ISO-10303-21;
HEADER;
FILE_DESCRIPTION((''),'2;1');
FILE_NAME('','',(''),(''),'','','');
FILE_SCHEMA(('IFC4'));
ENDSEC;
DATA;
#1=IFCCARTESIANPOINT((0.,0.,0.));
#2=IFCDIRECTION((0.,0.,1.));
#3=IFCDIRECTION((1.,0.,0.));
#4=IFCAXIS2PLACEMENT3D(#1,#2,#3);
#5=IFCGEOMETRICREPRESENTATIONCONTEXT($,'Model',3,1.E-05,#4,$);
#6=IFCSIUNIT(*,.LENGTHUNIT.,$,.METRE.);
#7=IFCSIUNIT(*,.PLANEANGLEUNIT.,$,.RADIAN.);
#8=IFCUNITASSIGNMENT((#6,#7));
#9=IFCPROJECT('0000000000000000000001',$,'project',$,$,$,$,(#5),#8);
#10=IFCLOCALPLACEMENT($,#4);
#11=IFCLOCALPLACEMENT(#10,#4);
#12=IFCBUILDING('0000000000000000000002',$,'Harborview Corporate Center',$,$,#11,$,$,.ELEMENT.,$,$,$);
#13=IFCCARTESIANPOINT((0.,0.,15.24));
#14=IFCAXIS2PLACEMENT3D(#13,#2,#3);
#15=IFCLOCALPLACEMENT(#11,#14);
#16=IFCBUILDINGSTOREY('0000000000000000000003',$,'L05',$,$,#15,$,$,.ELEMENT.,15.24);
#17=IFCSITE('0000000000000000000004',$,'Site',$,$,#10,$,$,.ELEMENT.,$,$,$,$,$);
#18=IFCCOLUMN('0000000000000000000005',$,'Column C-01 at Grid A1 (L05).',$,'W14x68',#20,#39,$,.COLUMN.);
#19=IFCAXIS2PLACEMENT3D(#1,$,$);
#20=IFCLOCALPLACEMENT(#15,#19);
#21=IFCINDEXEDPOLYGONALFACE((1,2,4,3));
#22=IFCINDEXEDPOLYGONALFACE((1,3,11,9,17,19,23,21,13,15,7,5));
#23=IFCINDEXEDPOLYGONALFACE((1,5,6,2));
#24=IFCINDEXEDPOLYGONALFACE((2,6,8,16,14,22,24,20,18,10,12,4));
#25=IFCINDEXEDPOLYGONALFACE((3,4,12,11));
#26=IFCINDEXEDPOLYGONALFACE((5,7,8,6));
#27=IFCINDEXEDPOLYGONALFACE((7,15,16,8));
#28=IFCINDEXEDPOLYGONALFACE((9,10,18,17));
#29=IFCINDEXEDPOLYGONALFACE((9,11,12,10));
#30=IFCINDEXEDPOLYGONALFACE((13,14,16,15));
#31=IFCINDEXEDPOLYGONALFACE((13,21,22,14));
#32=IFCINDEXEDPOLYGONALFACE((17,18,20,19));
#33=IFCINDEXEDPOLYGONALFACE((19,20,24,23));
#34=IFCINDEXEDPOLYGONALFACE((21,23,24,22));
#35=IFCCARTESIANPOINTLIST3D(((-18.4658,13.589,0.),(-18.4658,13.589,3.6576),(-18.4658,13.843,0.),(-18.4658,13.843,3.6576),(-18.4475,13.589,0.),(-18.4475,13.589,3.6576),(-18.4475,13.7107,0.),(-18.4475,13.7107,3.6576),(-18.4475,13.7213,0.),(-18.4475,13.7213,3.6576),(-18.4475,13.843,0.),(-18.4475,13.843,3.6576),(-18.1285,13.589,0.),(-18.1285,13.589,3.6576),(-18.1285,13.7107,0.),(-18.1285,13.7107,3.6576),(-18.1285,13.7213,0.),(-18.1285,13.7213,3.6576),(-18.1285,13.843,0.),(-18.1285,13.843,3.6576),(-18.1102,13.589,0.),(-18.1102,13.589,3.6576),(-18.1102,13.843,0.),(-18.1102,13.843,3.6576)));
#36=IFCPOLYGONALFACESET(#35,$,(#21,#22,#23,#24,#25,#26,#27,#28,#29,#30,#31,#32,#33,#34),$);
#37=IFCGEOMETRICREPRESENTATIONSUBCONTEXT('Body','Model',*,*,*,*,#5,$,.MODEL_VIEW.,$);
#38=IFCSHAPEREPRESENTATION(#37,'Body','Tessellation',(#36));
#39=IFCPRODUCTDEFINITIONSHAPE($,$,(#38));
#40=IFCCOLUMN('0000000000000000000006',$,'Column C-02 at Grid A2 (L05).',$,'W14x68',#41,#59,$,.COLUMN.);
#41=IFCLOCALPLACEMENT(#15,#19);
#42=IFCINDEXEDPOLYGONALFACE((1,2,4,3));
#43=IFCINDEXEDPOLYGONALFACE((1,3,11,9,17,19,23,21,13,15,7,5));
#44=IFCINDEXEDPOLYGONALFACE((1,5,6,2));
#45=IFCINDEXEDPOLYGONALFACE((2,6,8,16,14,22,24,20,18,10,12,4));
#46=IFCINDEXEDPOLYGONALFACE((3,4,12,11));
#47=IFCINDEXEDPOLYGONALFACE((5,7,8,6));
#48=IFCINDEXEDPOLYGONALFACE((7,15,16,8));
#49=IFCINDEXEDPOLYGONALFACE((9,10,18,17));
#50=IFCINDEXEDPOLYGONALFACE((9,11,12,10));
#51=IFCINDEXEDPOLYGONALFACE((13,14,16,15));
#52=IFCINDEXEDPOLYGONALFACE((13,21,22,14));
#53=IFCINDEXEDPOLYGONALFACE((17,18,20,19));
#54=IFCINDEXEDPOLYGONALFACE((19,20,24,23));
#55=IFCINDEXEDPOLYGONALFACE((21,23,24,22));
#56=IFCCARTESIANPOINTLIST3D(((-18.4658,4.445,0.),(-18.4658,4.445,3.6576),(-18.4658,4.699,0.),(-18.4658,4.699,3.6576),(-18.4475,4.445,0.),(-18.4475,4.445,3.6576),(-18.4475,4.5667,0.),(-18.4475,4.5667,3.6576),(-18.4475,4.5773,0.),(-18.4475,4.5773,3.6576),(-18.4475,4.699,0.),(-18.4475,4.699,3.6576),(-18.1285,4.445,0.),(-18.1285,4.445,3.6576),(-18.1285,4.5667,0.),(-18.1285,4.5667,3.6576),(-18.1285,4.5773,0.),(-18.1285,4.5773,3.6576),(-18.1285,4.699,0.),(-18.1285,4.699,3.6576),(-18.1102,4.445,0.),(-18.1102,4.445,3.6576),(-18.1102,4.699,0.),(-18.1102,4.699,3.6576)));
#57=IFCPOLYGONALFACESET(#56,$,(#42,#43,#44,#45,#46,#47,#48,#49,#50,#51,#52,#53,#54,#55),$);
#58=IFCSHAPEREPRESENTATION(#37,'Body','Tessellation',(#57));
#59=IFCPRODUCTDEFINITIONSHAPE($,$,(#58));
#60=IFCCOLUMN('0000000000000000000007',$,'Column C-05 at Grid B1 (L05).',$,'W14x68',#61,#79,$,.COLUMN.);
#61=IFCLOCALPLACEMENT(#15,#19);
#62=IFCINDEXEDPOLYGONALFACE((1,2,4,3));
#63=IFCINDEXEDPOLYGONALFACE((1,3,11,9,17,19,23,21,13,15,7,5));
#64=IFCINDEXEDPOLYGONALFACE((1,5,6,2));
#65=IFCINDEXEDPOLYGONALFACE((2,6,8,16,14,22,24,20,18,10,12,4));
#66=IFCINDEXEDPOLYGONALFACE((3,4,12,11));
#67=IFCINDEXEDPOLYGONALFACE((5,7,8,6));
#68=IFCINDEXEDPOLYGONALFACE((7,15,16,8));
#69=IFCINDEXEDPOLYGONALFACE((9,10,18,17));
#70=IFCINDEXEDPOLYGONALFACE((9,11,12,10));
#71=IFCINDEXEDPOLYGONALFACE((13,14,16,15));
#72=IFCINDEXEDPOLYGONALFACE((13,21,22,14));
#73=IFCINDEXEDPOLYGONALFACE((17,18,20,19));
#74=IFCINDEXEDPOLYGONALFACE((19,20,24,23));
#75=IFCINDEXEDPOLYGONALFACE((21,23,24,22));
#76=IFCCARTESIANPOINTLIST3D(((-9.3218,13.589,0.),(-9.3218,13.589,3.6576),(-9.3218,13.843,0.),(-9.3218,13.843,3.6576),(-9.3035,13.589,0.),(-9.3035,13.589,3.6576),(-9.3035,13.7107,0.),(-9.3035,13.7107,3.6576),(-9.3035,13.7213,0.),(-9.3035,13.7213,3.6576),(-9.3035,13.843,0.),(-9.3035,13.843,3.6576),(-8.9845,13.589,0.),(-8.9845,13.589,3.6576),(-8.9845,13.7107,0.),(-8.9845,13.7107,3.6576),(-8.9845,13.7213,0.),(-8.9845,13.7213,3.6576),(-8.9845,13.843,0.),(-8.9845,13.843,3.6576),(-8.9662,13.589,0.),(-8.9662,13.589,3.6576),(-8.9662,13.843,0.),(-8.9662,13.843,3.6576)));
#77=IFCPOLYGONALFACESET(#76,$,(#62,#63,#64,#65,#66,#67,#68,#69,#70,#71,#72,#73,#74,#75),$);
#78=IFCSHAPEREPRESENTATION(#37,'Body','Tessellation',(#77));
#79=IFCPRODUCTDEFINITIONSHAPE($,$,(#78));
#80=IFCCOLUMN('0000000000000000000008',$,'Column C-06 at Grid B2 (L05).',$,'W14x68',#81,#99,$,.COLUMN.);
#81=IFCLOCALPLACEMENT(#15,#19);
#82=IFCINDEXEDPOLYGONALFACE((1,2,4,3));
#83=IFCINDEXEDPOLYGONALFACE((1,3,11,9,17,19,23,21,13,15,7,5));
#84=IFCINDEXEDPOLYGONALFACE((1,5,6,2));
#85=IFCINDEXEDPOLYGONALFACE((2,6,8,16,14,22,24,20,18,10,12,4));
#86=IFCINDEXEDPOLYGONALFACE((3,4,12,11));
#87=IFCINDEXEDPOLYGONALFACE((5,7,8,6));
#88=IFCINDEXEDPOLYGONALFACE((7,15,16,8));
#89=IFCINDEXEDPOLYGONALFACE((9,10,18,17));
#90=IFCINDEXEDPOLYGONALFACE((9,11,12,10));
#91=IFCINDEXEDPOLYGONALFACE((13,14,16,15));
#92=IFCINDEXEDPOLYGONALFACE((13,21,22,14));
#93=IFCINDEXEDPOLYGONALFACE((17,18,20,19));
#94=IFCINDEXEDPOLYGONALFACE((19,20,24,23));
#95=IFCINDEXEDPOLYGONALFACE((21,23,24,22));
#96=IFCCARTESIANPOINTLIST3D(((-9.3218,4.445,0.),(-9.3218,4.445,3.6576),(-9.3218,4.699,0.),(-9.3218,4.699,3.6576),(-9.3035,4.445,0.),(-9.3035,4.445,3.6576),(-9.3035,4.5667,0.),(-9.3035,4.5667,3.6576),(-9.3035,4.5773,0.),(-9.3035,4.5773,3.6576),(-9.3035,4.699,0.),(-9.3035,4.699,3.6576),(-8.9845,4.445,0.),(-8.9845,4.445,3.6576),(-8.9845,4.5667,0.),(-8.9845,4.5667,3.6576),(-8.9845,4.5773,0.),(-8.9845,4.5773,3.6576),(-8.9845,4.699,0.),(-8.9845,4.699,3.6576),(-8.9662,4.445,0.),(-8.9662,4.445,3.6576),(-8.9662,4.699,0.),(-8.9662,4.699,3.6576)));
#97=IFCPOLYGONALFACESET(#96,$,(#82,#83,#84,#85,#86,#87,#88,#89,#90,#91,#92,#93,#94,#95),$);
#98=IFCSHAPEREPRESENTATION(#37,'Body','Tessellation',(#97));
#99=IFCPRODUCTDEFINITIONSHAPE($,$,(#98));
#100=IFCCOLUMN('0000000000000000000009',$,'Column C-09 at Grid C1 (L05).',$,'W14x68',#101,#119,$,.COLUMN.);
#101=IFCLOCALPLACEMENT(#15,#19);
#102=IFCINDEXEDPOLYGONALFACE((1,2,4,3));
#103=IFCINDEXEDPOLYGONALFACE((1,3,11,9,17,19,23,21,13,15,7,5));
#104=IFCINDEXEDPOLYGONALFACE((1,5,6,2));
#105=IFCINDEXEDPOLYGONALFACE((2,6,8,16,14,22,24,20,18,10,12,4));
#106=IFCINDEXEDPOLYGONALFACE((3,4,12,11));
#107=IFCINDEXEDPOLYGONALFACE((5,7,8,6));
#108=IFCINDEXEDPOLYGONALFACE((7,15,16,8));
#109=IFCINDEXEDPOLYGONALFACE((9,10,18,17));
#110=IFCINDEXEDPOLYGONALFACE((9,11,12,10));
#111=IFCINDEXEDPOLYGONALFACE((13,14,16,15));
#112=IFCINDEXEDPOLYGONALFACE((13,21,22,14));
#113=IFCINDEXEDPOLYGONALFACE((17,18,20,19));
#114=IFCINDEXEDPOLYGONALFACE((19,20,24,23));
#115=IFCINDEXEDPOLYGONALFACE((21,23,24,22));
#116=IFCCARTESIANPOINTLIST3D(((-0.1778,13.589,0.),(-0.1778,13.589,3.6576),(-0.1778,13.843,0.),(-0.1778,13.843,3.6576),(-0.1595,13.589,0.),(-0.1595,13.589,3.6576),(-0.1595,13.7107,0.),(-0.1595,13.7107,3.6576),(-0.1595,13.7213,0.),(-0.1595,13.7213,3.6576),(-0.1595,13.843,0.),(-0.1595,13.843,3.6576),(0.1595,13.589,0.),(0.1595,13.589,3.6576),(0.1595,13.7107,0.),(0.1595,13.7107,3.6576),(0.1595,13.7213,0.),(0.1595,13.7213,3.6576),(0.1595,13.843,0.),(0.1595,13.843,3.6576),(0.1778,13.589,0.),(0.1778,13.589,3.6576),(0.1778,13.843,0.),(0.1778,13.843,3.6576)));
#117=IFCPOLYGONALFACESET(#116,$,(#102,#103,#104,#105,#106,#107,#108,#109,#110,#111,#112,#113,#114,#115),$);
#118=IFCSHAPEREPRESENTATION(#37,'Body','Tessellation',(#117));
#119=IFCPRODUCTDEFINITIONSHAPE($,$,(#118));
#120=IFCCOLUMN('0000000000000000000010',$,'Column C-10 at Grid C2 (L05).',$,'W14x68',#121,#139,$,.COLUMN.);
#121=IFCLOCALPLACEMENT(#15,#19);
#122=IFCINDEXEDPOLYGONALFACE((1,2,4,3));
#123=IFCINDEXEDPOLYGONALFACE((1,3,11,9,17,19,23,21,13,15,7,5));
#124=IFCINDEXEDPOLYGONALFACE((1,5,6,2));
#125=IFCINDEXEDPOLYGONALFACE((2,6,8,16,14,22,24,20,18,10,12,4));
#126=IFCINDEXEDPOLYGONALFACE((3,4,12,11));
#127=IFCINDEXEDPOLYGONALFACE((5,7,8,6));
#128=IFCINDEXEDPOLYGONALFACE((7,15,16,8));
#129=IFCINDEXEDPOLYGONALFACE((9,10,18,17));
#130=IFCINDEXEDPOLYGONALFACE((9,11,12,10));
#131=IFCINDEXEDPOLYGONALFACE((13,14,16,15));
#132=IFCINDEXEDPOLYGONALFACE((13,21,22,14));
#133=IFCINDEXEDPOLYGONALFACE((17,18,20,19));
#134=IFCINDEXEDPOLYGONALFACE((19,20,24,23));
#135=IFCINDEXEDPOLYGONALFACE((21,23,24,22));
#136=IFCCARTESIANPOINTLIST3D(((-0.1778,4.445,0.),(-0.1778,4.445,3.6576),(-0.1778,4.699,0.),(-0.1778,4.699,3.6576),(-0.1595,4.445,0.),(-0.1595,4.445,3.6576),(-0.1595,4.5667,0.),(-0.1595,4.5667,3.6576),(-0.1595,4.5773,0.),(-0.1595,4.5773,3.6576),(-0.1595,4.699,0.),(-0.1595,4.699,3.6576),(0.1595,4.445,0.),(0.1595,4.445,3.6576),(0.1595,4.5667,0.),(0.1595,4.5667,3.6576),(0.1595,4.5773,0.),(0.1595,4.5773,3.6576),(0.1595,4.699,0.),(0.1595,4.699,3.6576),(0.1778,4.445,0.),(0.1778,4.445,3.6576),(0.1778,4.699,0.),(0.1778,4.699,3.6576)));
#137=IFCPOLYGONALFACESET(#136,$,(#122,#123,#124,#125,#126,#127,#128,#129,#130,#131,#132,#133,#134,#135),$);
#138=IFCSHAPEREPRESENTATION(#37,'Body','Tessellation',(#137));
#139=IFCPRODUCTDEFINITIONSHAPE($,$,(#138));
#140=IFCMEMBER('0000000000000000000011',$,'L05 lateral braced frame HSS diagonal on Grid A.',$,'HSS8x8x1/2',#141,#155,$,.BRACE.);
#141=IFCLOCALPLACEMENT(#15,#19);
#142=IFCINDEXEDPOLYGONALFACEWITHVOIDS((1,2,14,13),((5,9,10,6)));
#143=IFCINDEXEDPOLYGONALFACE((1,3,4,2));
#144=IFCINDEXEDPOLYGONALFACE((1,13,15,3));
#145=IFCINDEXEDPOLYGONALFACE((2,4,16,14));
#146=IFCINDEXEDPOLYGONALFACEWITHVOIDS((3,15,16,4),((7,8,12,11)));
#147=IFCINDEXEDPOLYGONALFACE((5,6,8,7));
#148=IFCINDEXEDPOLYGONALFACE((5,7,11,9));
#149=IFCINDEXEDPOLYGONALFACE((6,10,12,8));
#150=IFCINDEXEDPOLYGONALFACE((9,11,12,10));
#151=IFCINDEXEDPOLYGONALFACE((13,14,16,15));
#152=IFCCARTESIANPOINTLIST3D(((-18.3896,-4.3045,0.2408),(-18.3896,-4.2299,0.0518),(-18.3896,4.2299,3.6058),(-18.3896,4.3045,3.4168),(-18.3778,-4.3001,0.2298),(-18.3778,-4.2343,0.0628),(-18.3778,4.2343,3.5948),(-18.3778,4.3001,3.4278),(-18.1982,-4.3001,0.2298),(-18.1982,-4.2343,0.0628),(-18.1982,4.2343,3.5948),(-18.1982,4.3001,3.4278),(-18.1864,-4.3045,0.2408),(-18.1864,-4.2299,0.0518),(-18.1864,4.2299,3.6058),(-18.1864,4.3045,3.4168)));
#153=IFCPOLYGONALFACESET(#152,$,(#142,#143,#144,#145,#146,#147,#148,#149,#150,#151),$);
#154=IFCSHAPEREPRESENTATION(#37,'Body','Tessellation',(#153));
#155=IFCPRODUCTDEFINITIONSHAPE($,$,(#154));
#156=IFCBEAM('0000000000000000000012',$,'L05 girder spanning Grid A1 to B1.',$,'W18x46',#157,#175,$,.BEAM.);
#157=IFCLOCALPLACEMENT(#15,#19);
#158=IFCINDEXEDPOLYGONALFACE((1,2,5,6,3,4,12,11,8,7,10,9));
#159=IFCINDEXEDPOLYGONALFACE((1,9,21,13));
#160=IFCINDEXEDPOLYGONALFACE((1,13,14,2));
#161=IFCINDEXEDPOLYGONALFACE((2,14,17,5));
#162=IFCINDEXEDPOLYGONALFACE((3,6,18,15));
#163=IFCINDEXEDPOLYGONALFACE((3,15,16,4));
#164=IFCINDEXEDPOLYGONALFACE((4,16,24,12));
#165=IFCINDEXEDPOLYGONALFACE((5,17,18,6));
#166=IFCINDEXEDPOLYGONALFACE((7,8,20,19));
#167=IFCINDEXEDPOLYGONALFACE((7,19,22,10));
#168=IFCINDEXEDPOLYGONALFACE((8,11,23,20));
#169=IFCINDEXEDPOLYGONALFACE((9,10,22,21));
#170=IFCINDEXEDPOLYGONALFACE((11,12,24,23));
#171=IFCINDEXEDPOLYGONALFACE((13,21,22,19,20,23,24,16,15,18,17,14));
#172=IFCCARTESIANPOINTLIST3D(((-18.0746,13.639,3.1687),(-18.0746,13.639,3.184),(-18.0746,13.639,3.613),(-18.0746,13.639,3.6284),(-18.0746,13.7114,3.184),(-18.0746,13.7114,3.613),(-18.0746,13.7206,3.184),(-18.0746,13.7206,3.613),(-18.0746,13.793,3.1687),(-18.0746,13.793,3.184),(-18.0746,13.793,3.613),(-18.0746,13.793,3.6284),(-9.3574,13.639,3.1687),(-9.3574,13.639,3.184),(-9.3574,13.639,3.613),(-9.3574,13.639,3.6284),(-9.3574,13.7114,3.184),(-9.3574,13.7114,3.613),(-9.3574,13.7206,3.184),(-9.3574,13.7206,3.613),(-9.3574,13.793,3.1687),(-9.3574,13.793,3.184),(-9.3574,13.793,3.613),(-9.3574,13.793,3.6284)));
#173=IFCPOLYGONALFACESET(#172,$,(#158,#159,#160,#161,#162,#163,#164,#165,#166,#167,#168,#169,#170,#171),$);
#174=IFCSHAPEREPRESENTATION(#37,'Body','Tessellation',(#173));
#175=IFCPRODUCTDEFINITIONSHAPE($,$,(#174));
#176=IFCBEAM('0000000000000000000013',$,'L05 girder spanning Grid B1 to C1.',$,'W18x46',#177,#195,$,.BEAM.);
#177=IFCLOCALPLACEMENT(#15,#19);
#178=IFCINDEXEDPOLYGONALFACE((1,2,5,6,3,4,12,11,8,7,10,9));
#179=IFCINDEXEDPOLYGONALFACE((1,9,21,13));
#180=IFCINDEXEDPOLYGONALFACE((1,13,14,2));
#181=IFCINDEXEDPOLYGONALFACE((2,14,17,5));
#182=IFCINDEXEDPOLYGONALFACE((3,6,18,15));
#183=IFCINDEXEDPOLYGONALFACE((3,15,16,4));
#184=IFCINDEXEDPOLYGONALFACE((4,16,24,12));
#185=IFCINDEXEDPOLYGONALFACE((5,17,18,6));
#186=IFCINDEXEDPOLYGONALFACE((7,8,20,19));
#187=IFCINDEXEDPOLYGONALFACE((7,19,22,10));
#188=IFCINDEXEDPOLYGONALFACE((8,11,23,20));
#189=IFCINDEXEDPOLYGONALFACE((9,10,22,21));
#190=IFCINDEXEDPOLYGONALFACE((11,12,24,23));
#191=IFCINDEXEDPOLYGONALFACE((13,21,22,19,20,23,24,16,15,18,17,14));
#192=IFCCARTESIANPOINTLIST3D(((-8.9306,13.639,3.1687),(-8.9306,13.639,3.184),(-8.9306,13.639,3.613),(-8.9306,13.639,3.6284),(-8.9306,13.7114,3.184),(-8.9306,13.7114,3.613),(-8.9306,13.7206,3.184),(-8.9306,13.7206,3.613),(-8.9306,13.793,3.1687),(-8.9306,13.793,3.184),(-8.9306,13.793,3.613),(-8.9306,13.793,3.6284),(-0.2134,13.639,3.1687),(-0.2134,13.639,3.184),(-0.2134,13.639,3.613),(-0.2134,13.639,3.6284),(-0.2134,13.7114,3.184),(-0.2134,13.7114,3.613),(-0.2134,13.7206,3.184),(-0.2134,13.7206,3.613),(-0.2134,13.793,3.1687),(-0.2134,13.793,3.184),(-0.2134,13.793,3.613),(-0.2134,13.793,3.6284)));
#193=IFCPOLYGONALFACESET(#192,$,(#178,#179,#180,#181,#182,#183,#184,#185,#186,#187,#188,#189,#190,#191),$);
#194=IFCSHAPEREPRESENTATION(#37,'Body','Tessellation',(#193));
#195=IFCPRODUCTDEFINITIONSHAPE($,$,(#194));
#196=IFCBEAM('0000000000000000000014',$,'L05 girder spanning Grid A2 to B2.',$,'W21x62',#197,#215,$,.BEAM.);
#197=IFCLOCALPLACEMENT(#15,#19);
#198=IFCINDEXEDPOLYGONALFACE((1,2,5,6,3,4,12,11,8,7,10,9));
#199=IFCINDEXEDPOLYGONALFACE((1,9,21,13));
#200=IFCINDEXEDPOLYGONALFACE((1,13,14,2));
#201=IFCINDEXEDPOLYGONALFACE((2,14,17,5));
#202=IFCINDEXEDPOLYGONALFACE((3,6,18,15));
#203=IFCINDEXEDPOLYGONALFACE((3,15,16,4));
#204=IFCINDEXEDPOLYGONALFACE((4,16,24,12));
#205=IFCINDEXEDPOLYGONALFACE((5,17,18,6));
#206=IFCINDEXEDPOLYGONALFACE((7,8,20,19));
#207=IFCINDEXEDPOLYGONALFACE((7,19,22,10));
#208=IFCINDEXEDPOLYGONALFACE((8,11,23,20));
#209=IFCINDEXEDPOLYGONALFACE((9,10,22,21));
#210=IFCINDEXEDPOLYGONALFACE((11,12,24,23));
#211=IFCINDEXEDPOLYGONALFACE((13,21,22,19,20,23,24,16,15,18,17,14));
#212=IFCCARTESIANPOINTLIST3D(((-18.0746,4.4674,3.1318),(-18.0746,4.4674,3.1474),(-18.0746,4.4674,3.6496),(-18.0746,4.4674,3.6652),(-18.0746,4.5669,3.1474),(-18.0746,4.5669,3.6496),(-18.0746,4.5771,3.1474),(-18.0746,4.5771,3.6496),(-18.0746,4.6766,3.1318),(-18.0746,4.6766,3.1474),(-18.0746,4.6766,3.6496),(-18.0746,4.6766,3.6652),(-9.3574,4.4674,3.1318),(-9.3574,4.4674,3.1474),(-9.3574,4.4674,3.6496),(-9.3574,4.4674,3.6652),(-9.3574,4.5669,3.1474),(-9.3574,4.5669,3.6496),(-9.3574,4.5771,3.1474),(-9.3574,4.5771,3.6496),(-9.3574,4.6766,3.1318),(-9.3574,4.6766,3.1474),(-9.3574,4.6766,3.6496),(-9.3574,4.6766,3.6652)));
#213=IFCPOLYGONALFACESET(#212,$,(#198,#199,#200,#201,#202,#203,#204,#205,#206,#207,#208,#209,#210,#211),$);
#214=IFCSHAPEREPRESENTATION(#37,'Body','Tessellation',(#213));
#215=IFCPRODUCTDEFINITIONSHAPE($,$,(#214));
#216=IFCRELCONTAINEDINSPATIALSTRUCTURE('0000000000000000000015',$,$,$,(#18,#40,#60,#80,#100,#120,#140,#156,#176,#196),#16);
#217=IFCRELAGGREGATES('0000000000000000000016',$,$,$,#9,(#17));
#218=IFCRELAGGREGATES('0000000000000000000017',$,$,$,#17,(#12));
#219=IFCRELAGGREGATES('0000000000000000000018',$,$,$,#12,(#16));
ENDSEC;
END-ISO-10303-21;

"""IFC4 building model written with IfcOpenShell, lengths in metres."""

from ifc_helpers import new_model, si_unit, frame, origin_with_axes, place, context, subcontext, project, spatial, hollow_rectangle, i_section, extrude, element, save


model = new_model("IFC4")

# Units and contexts
model_context = context("Model", 3, precision=1e-05, world=origin_with_axes())
body_context = subcontext(model_context, "Body", "Model", "MODEL_VIEW")
ifc_project = project(units=[si_unit("LENGTHUNIT", "METRE"), si_unit("PLANEANGLEUNIT", "RADIAN")], contexts=[model_context])

# Site, building, storey
site_placement = place(None, origin_with_axes())
site = spatial("IfcSite", under=ifc_project, at=site_placement, Name="Site", CompositionType="ELEMENT")
building_placement = place(site_placement, origin_with_axes())
building = spatial("IfcBuilding", under=site, at=building_placement, Name="Harborview Corporate Center", CompositionType="ELEMENT")
storey_placement = place(building_placement, frame((0.0, 0.0, 15.24), z_axis=(0.0, 0.0, 1.0), x_axis=(1.0, 0.0, 0.0)))
storey = spatial("IfcBuildingStorey", under=building, at=storey_placement, Name="L05", CompositionType="ELEMENT", Elevation=15.24)

# Columns
for number, where, z_axis, x_axis, name in (
    (1, (-18.288, 13.716, 0.0), (0.0, 0.0, 1.0), (0.0, 1.0, 0.0), "Column C-01 at Grid A1 (L05)."),
    (2, (-18.288, 4.572, 0.0), (0.0, 0.0, 1.0), (0.0, 1.0, 0.0), "Column C-02 at Grid A2 (L05)."),
    (3, (-9.144, 13.716, 0.0), (0.0, 0.0, 1.0), (0.0, 1.0, 0.0), "Column C-05 at Grid B1 (L05)."),
    (4, (-9.144, 4.572, 0.0), (0.0, 0.0, 1.0), (0.0, 1.0, 0.0), "Column C-06 at Grid B2 (L05)."),
    (5, (0.0, 13.716, 0.0), (0.0, 0.0, 1.0), (0.0, 1.0, 0.0), "Column C-09 at Grid C1 (L05)."),
    (6, (0.0, 4.572, 0.0), (0.0, 0.0, 1.0), (0.0, 1.0, 0.0), "Column C-10 at Grid C2 (L05)."),
):
    element("IfcColumn", number, at=place(storey_placement, frame(where, z_axis=z_axis, x_axis=x_axis)), inside=storey, Name=name, ObjectType="W14x68", PredefinedType="COLUMN", context=body_context, shape_type="SweptSolid", body=[
        extrude(i_section(OverallWidth=0.254, OverallDepth=0.3556, WebThickness=0.0105, FlangeThickness=0.0183), origin_with_axes(), (0.0, 0.0, 1.0), 3.6576),
    ])

# Member
member_placement = place(storey_placement, frame((-18.288, -4.2672, 0.1463), z_axis=(0.0, 0.930298, 0.366803), x_axis=(-1.0, 0.0, 0.0)))
element("IfcMember", 7, at=member_placement, inside=storey, Name="L05 lateral braced frame HSS diagonal on Grid A.", ObjectType="HSS8x8x1/2", PredefinedType="BRACE", context=body_context, shape_type="SweptSolid", body=[
    extrude(hollow_rectangle(XDim=0.2032, YDim=0.2032, WallThickness=0.0118), origin_with_axes(), (0.0, 0.0, 1.0), 9.1738),
])

# Beams
beam_1_placement = place(storey_placement, frame((-18.0746, 13.716, 3.3985), z_axis=(1.0, 0.0, 0.0), x_axis=(0.0, 1.0, 0.0)))
element("IfcBeam", 8, at=beam_1_placement, inside=storey, Name="L05 girder spanning Grid A1 to B1.", ObjectType="W18x46", PredefinedType="BEAM", context=body_context, shape_type="SweptSolid", body=[
    extrude(i_section(OverallWidth=0.1539, OverallDepth=0.4597, WebThickness=0.0091, FlangeThickness=0.0154), origin_with_axes(), (0.0, 0.0, 1.0), 8.7173),
])
beam_2_placement = place(storey_placement, frame((-8.9306, 13.716, 3.3985), z_axis=(1.0, 0.0, 0.0), x_axis=(0.0, 1.0, 0.0)))
element("IfcBeam", 9, at=beam_2_placement, inside=storey, Name="L05 girder spanning Grid B1 to C1.", ObjectType="W18x46", PredefinedType="BEAM", context=body_context, shape_type="SweptSolid", body=[
    extrude(i_section(OverallWidth=0.1539, OverallDepth=0.4597, WebThickness=0.0091, FlangeThickness=0.0154), origin_with_axes(), (0.0, 0.0, 1.0), 8.7173),
])
beam_3_placement = place(storey_placement, frame((-18.0746, 4.572, 3.3985), z_axis=(1.0, 0.0, 0.0), x_axis=(0.0, 1.0, 0.0)))
element("IfcBeam", 10, at=beam_3_placement, inside=storey, Name="L05 girder spanning Grid A2 to B2.", ObjectType="W21x62", PredefinedType="BEAM", context=body_context, shape_type="SweptSolid", body=[
    extrude(i_section(OverallWidth=0.2093, OverallDepth=0.5334, WebThickness=0.0102, FlangeThickness=0.0156), origin_with_axes(), (0.0, 0.0, 1.0), 8.7173),
])

save(model, "model.ifc")
